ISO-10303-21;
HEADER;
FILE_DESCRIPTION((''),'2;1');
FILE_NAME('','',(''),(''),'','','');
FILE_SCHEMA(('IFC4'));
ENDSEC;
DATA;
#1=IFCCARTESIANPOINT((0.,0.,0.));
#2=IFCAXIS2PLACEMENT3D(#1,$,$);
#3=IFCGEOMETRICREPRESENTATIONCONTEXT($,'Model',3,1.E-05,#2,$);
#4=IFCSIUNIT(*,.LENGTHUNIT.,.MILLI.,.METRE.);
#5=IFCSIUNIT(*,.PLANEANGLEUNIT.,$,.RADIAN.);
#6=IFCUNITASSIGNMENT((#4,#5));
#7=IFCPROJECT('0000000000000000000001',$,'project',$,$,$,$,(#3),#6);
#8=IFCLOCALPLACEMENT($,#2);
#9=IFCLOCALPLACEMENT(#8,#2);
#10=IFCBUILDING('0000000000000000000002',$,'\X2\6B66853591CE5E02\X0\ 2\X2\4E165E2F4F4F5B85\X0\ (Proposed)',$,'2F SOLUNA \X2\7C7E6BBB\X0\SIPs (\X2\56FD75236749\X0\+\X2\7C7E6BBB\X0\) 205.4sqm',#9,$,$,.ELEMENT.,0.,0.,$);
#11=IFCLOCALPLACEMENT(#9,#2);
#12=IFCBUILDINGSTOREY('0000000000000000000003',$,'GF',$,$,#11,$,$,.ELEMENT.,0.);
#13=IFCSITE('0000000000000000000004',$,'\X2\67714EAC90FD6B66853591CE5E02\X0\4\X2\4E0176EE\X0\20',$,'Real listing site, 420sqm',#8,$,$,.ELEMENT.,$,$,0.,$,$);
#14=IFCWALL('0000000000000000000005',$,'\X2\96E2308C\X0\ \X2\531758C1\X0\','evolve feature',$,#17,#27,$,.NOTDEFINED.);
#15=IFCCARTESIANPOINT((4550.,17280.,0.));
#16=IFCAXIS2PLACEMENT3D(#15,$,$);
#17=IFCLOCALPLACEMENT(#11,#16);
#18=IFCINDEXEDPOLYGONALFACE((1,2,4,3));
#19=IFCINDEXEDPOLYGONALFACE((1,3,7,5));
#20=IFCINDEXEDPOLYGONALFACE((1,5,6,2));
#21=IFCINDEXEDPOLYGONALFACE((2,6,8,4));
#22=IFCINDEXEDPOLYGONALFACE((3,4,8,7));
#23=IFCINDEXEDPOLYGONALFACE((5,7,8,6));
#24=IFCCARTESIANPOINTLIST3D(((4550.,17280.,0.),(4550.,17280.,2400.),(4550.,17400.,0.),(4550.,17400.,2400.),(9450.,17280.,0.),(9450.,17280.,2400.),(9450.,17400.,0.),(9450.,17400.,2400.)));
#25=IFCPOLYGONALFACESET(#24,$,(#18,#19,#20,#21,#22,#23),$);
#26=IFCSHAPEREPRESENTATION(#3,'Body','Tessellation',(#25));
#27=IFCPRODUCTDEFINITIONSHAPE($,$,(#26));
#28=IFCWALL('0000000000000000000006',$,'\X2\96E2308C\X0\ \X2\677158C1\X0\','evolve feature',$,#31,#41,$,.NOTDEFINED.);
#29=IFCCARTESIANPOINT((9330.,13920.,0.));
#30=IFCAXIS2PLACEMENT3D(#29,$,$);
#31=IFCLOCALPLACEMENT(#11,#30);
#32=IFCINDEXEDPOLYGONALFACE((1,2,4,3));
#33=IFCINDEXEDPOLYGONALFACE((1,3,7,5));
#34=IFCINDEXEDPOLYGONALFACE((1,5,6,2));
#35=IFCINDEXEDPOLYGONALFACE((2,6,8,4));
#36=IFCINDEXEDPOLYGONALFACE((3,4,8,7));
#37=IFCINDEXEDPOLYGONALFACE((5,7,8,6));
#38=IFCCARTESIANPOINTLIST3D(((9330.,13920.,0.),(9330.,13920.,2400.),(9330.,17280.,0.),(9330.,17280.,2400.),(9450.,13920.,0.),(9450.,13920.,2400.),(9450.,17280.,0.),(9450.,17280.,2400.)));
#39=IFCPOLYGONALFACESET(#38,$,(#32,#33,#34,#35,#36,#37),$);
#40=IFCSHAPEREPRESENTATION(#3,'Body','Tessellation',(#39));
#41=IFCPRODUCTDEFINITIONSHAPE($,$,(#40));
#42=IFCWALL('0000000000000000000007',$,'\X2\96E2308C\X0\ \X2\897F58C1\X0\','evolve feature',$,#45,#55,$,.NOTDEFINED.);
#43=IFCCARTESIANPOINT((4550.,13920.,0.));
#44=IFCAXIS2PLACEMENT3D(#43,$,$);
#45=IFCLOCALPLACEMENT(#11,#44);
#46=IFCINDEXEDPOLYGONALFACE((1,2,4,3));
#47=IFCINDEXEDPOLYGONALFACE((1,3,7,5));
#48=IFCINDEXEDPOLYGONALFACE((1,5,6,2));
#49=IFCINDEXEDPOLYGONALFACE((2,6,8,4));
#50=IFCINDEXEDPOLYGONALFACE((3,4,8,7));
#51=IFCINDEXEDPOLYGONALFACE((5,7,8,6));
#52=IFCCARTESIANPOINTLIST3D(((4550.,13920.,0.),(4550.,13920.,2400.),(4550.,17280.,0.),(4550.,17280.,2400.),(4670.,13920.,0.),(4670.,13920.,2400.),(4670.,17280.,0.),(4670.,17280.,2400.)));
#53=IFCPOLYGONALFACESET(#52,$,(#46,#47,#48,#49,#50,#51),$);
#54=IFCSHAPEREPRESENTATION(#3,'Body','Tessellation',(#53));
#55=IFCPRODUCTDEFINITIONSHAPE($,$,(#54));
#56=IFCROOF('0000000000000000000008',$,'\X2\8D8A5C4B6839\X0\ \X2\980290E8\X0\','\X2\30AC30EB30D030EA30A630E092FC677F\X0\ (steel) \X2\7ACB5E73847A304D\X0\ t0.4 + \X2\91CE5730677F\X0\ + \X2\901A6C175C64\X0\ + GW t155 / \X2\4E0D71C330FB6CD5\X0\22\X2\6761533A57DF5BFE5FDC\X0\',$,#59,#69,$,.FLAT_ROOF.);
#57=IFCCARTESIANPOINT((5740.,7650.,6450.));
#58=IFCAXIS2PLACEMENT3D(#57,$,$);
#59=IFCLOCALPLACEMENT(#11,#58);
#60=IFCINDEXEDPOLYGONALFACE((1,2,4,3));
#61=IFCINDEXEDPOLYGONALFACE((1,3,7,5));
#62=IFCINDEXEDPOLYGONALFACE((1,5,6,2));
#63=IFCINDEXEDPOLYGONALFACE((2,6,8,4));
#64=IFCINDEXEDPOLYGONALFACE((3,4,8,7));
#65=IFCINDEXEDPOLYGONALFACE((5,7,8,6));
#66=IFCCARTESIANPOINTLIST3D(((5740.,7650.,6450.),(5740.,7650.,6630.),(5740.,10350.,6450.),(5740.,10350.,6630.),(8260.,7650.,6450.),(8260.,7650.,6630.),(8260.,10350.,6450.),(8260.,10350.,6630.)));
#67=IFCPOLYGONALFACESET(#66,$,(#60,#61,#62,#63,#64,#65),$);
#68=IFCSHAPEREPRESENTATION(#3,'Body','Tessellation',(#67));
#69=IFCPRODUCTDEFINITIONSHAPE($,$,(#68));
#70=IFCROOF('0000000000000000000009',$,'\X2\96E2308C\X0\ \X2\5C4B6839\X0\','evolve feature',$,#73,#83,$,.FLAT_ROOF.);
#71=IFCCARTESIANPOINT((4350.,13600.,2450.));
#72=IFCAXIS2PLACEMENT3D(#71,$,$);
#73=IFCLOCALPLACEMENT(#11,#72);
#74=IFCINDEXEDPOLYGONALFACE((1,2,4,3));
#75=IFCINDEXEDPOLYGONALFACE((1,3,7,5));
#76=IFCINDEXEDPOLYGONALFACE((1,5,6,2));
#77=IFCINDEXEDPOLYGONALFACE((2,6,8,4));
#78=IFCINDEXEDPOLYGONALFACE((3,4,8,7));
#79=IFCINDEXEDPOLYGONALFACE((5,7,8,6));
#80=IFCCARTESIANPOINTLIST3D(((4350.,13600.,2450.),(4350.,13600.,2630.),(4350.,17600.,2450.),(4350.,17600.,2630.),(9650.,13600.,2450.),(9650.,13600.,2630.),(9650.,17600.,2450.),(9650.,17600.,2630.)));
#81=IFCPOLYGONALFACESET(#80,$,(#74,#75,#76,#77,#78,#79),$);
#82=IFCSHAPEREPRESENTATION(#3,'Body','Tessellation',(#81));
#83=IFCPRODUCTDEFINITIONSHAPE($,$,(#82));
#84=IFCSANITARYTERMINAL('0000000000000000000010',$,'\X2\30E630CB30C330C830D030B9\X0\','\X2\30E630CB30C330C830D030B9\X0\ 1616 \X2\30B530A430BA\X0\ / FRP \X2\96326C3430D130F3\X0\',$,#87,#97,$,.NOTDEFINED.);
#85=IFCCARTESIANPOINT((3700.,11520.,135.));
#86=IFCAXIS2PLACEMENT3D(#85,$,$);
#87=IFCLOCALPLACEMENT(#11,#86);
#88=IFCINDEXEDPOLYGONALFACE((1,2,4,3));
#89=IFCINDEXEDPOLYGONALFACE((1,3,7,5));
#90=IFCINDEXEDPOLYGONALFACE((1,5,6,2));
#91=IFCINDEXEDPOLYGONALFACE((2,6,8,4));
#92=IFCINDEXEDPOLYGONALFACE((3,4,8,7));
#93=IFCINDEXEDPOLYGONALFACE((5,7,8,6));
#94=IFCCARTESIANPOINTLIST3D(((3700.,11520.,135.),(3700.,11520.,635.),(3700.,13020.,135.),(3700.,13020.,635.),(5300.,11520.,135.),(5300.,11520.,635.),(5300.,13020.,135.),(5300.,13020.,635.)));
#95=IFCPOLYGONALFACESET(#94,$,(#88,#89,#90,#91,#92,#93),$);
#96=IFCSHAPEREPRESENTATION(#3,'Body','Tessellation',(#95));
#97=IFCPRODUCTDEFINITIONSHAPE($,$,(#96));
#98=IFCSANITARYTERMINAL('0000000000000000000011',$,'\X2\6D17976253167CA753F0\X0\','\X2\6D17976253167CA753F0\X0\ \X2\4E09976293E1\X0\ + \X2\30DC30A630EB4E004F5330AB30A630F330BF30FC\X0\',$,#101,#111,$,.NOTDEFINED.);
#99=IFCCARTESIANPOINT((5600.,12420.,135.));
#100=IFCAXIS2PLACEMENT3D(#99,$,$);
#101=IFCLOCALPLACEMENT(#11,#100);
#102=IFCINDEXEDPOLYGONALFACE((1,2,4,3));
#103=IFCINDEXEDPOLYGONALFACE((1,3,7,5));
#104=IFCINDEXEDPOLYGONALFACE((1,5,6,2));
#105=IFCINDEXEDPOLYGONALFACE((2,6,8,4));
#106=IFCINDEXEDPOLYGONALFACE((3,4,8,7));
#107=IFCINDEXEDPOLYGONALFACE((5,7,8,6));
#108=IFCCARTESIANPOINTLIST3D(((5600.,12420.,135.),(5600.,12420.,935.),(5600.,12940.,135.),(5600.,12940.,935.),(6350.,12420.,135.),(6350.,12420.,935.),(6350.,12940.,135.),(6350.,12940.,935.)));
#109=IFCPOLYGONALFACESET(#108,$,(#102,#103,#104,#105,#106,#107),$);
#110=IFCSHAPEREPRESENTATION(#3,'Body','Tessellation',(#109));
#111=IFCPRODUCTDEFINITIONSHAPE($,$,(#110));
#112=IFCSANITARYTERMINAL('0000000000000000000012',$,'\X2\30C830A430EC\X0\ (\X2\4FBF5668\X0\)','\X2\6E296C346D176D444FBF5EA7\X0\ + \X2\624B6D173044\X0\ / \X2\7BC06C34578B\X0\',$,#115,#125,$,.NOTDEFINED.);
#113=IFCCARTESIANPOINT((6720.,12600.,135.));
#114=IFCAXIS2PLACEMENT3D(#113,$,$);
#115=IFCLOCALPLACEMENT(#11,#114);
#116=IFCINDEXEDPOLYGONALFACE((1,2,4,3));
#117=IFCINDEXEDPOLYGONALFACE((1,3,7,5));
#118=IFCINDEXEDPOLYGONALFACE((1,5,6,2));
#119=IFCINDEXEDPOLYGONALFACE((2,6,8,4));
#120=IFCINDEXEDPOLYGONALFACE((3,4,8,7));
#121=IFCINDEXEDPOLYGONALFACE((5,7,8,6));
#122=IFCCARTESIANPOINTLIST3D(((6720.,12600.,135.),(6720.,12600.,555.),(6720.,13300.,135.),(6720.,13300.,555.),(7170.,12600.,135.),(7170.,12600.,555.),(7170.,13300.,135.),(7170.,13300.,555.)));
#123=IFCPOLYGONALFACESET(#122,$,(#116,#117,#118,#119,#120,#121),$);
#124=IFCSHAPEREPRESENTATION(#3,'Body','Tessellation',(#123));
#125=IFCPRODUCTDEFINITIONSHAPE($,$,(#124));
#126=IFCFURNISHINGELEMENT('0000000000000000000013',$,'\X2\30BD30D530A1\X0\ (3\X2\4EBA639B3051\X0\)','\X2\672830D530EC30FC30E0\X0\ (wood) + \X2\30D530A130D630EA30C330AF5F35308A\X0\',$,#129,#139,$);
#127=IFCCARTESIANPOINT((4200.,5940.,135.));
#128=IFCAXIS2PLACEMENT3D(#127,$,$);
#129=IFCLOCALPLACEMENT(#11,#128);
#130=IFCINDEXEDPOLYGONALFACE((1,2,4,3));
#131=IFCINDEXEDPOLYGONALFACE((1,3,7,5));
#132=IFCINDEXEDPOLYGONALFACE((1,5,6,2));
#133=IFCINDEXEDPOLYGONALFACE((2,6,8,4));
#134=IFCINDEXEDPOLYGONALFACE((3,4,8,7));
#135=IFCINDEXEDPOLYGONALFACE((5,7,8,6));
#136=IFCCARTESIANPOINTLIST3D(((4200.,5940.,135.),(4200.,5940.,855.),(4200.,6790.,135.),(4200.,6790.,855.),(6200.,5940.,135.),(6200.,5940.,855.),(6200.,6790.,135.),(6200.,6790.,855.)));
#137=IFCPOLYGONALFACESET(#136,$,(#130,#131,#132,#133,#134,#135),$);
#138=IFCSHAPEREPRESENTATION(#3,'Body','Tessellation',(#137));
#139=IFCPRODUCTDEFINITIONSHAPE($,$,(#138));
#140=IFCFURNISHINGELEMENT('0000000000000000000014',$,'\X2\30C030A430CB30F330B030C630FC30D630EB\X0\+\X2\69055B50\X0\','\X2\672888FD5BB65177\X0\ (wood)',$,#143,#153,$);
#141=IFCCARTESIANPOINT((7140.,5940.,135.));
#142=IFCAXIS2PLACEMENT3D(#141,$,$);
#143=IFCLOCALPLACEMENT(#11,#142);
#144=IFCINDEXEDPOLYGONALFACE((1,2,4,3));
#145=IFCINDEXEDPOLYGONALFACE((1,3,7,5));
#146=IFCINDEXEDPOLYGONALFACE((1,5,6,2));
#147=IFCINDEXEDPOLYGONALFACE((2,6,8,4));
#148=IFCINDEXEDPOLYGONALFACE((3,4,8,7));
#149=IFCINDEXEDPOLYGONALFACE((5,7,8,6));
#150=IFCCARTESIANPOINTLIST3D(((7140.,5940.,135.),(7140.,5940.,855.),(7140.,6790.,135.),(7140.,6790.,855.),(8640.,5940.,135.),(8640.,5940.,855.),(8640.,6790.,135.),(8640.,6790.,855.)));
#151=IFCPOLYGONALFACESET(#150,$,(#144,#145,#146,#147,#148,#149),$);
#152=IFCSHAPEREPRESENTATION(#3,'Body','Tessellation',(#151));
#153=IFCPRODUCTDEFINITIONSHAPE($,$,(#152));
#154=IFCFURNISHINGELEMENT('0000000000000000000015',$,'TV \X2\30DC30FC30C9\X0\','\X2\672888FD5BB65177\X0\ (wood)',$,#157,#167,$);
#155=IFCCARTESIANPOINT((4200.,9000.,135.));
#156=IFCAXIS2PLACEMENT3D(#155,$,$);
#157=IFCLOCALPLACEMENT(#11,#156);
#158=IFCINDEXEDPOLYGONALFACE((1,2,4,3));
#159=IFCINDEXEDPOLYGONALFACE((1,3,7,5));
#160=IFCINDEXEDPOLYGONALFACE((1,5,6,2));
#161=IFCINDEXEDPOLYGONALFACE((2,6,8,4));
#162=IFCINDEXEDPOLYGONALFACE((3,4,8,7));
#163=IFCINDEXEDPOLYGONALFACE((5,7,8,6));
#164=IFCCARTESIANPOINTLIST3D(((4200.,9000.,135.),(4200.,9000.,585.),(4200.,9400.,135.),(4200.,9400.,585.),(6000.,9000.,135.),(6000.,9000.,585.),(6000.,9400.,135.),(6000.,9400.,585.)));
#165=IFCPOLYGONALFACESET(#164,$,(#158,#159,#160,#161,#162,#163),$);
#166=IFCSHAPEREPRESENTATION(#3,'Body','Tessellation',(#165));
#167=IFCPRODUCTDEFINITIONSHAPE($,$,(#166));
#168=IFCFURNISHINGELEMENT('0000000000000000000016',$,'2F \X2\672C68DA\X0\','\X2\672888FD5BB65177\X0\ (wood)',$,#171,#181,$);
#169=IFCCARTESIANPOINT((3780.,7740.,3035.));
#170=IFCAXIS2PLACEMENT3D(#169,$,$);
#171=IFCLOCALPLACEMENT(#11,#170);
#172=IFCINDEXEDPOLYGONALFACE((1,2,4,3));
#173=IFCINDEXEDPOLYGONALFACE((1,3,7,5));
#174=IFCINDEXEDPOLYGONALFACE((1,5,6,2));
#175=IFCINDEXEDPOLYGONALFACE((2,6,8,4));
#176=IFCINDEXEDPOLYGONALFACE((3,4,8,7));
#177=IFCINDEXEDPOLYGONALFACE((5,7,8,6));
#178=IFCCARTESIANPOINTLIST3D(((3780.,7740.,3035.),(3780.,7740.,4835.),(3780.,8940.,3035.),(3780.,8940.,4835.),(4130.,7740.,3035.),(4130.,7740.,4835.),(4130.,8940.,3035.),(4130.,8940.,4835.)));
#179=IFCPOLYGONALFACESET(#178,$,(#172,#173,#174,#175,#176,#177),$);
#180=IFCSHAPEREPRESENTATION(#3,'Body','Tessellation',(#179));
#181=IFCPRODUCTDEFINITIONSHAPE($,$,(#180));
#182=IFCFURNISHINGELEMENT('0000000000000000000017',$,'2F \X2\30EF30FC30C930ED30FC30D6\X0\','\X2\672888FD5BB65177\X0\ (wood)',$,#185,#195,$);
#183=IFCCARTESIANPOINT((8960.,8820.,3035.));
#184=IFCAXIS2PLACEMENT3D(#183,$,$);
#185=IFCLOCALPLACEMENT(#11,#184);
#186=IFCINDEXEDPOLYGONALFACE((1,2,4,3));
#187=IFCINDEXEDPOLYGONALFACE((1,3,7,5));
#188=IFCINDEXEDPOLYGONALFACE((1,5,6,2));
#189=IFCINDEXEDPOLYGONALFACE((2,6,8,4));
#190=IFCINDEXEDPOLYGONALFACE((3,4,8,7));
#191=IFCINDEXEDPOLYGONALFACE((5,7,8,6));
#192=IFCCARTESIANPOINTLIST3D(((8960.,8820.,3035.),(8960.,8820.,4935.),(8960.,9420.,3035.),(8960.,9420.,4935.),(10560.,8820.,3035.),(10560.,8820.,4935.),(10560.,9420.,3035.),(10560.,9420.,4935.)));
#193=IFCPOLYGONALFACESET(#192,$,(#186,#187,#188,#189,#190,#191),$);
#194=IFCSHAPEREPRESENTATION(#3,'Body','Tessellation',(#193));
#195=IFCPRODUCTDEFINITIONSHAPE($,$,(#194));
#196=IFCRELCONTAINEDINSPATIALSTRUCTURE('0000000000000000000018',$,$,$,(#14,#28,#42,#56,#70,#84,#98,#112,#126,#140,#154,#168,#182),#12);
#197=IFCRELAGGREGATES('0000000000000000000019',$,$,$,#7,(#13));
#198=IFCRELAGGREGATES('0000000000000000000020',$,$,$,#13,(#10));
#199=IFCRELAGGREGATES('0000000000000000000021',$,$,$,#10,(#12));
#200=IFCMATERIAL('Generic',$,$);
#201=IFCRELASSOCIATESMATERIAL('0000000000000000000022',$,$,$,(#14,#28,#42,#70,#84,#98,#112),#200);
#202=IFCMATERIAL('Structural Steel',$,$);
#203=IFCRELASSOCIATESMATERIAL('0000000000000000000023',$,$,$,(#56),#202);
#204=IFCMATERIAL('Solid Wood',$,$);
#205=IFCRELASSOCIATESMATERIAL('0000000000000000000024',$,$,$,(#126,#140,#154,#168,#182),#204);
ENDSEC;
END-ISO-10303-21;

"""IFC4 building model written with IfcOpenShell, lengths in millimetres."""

from ifc_helpers import new_model, si_unit, frame, frame_2d, origin, place, context, project, spatial, rectangle, extrude, material, element, save


model = new_model("IFC4")

# Units and contexts
model_context = context("Model", 3, precision=1e-05, world=origin())
ifc_project = project(units=[si_unit("LENGTHUNIT", "METRE", prefix="MILLI"), si_unit("PLANEANGLEUNIT", "RADIAN")], contexts=[model_context])

# Site, building, storey
site_placement = place(None, origin())
site = spatial("IfcSite", under=ifc_project, at=site_placement, Name="東京都武蔵野市4丁目20", ObjectType="Real listing site, 420sqm", CompositionType="ELEMENT", RefElevation=0.0)
building_placement = place(site_placement, origin())
building = spatial("IfcBuilding", under=site, at=building_placement, Name="武蔵野市 2世帯住宅 (Proposed)", ObjectType="2F SOLUNA 籾殻SIPs (国産杉+籾殻) 205.4sqm", CompositionType="ELEMENT", ElevationOfRefHeight=0.0, ElevationOfTerrain=0.0)
storey_placement = place(building_placement, origin())
storey = spatial("IfcBuildingStorey", under=building, at=storey_placement, Name="GF", CompositionType="ELEMENT", Elevation=0.0)

# Shared definitions
ifc_material_1 = material(Name="Generic")

# Shared definitions
ifc_material_2 = material(Name="Solid Wood")

# Walls
wall_1_placement = place(storey_placement, frame((4550.0, 17280.0, 0.0)))
element("IfcWall", 1, at=wall_1_placement, inside=storey, material=ifc_material_1, Name="離れ 北壁", Description="evolve feature", PredefinedType="NOTDEFINED", context=model_context, shape_type="SweptSolid", body=[
    extrude(rectangle(XDim=4900.0, YDim=120.0, at=frame_2d((2450.0, 60.0))), frame((4550.0, 17280.0, 0.0)), (0.0, 0.0, 1.0), 2400.0),
])
wall_2_placement = place(storey_placement, frame((9330.0, 13920.0, 0.0)))
element("IfcWall", 2, at=wall_2_placement, inside=storey, material=ifc_material_1, Name="離れ 東壁", Description="evolve feature", PredefinedType="NOTDEFINED", context=model_context, shape_type="SweptSolid", body=[
    extrude(rectangle(XDim=120.0, YDim=3360.0, at=frame_2d((60.0, 1680.0))), frame((9330.0, 13920.0, 0.0)), (0.0, 0.0, 1.0), 2400.0),
])
wall_3_placement = place(storey_placement, frame((4550.0, 13920.0, 0.0)))
element("IfcWall", 3, at=wall_3_placement, inside=storey, material=ifc_material_1, Name="離れ 西壁", Description="evolve feature", PredefinedType="NOTDEFINED", context=model_context, shape_type="SweptSolid", body=[
    extrude(rectangle(XDim=120.0, YDim=3360.0, at=frame_2d((60.0, 1680.0))), frame((4550.0, 13920.0, 0.0)), (0.0, 0.0, 1.0), 2400.0),
])

# Roofs
ifc_material_3 = material(Name="Structural Steel")
roof_1_placement = place(storey_placement, frame((5740.0, 7650.0, 6450.0)))
element("IfcRoof", 4, at=roof_1_placement, inside=storey, material=ifc_material_3, Name="越屋根 頂部", Description="ガルバリウム鋼板 (steel) 立平葺き t0.4 + 野地板 + 通気層 + GW t155 / 不燃・法22条区域対応", PredefinedType="FLAT_ROOF", context=model_context, shape_type="SweptSolid", body=[
    extrude(rectangle(XDim=2520.0, YDim=2700.0, at=frame_2d((1260.0, 1350.0))), frame((5740.0, 7650.0, 6450.0)), (0.0, 0.0, 1.0), 180.0),
])
roof_2_placement = place(storey_placement, frame((4350.0, 13600.0, 2450.0)))
element("IfcRoof", 5, at=roof_2_placement, inside=storey, material=ifc_material_1, Name="離れ 屋根", Description="evolve feature", PredefinedType="FLAT_ROOF", context=model_context, shape_type="SweptSolid", body=[
    extrude(rectangle(XDim=5300.0, YDim=4000.0, at=frame_2d((2650.0, 2000.0))), frame((4350.0, 13600.0, 2450.0)), (0.0, 0.0, 1.0), 180.0),
])

# Sanitary terminals
sanitary_terminal_1_placement = place(storey_placement, frame((3700.0, 11520.0, 135.0)))
element("IfcSanitaryTerminal", 6, at=sanitary_terminal_1_placement, inside=storey, material=ifc_material_1, Name="ユニットバス", Description="ユニットバス 1616 サイズ / FRP 防水パン", PredefinedType="NOTDEFINED", context=model_context, shape_type="SweptSolid", body=[
    extrude(rectangle(XDim=1600.0, YDim=1500.0, at=frame_2d((800.0, 750.0))), frame((3700.0, 11520.0, 135.0)), (0.0, 0.0, 1.0), 500.0),
])
sanitary_terminal_2_placement = place(storey_placement, frame((5600.0, 12420.0, 135.0)))
element("IfcSanitaryTerminal", 7, at=sanitary_terminal_2_placement, inside=storey, material=ifc_material_1, Name="洗面化粧台", Description="洗面化粧台 三面鏡 + ボウル一体カウンター", PredefinedType="NOTDEFINED", context=model_context, shape_type="SweptSolid", body=[
    extrude(rectangle(XDim=750.0, YDim=520.0, at=frame_2d((375.0, 260.0))), frame((5600.0, 12420.0, 135.0)), (0.0, 0.0, 1.0), 800.0),
])
sanitary_terminal_3_placement = place(storey_placement, frame((6720.0, 12600.0, 135.0)))
element("IfcSanitaryTerminal", 8, at=sanitary_terminal_3_placement, inside=storey, material=ifc_material_1, Name="トイレ (便器)", Description="温水洗浄便座 + 手洗い / 節水型", PredefinedType="NOTDEFINED", context=model_context, shape_type="SweptSolid", body=[
    extrude(rectangle(XDim=450.0, YDim=700.0, at=frame_2d((225.0, 350.0))), frame((6720.0, 12600.0, 135.0)), (0.0, 0.0, 1.0), 420.0),
])

# Furnishing elements
furnishing_1_placement = place(storey_placement, frame((4200.0, 5940.0, 135.0)))
element("IfcFurnishingElement", 9, at=furnishing_1_placement, inside=storey, material=ifc_material_2, Name="ソファ (3人掛け)", Description="木フレーム (wood) + ファブリック張り", context=model_context, shape_type="SweptSolid", body=[
    extrude(rectangle(XDim=2000.0, YDim=850.0, at=frame_2d((1000.0, 425.0))), frame((4200.0, 5940.0, 135.0)), (0.0, 0.0, 1.0), 720.0),
])
furnishing_2_placement = place(storey_placement, frame((7140.0, 5940.0, 135.0)))
element("IfcFurnishingElement", 10, at=furnishing_2_placement, inside=storey, material=ifc_material_2, Name="ダイニングテーブル+椅子", Description="木製家具 (wood)", context=model_context, shape_type="SweptSolid", body=[
    extrude(rectangle(XDim=1500.0, YDim=850.0, at=frame_2d((750.0, 425.0))), frame((7140.0, 5940.0, 135.0)), (0.0, 0.0, 1.0), 720.0),
])
furnishing_3_placement = place(storey_placement, frame((4200.0, 9000.0, 135.0)))
element("IfcFurnishingElement", 11, at=furnishing_3_placement, inside=storey, material=ifc_material_2, Name="TV ボード", Description="木製家具 (wood)", context=model_context, shape_type="SweptSolid", body=[
    extrude(rectangle(XDim=1800.0, YDim=400.0, at=frame_2d((900.0, 200.0))), frame((4200.0, 9000.0, 135.0)), (0.0, 0.0, 1.0), 450.0),
])
furnishing_4_placement = place(storey_placement, frame((3780.0, 7740.0, 3035.0)))
element("IfcFurnishingElement", 12, at=furnishing_4_placement, inside=storey, material=ifc_material_2, Name="2F 本棚", Description="木製家具 (wood)", context=model_context, shape_type="SweptSolid", body=[
    extrude(rectangle(XDim=350.0, YDim=1200.0, at=frame_2d((175.0, 600.0))), frame((3780.0, 7740.0, 3035.0)), (0.0, 0.0, 1.0), 1800.0),
])
furnishing_5_placement = place(storey_placement, frame((8960.0, 8820.0, 3035.0)))
element("IfcFurnishingElement", 13, at=furnishing_5_placement, inside=storey, material=ifc_material_2, Name="2F ワードローブ", Description="木製家具 (wood)", context=model_context, shape_type="SweptSolid", body=[
    extrude(rectangle(XDim=1600.0, YDim=600.0, at=frame_2d((800.0, 300.0))), frame((8960.0, 8820.0, 3035.0)), (0.0, 0.0, 1.0), 1900.0),
])

save(model, "model.ifc")
